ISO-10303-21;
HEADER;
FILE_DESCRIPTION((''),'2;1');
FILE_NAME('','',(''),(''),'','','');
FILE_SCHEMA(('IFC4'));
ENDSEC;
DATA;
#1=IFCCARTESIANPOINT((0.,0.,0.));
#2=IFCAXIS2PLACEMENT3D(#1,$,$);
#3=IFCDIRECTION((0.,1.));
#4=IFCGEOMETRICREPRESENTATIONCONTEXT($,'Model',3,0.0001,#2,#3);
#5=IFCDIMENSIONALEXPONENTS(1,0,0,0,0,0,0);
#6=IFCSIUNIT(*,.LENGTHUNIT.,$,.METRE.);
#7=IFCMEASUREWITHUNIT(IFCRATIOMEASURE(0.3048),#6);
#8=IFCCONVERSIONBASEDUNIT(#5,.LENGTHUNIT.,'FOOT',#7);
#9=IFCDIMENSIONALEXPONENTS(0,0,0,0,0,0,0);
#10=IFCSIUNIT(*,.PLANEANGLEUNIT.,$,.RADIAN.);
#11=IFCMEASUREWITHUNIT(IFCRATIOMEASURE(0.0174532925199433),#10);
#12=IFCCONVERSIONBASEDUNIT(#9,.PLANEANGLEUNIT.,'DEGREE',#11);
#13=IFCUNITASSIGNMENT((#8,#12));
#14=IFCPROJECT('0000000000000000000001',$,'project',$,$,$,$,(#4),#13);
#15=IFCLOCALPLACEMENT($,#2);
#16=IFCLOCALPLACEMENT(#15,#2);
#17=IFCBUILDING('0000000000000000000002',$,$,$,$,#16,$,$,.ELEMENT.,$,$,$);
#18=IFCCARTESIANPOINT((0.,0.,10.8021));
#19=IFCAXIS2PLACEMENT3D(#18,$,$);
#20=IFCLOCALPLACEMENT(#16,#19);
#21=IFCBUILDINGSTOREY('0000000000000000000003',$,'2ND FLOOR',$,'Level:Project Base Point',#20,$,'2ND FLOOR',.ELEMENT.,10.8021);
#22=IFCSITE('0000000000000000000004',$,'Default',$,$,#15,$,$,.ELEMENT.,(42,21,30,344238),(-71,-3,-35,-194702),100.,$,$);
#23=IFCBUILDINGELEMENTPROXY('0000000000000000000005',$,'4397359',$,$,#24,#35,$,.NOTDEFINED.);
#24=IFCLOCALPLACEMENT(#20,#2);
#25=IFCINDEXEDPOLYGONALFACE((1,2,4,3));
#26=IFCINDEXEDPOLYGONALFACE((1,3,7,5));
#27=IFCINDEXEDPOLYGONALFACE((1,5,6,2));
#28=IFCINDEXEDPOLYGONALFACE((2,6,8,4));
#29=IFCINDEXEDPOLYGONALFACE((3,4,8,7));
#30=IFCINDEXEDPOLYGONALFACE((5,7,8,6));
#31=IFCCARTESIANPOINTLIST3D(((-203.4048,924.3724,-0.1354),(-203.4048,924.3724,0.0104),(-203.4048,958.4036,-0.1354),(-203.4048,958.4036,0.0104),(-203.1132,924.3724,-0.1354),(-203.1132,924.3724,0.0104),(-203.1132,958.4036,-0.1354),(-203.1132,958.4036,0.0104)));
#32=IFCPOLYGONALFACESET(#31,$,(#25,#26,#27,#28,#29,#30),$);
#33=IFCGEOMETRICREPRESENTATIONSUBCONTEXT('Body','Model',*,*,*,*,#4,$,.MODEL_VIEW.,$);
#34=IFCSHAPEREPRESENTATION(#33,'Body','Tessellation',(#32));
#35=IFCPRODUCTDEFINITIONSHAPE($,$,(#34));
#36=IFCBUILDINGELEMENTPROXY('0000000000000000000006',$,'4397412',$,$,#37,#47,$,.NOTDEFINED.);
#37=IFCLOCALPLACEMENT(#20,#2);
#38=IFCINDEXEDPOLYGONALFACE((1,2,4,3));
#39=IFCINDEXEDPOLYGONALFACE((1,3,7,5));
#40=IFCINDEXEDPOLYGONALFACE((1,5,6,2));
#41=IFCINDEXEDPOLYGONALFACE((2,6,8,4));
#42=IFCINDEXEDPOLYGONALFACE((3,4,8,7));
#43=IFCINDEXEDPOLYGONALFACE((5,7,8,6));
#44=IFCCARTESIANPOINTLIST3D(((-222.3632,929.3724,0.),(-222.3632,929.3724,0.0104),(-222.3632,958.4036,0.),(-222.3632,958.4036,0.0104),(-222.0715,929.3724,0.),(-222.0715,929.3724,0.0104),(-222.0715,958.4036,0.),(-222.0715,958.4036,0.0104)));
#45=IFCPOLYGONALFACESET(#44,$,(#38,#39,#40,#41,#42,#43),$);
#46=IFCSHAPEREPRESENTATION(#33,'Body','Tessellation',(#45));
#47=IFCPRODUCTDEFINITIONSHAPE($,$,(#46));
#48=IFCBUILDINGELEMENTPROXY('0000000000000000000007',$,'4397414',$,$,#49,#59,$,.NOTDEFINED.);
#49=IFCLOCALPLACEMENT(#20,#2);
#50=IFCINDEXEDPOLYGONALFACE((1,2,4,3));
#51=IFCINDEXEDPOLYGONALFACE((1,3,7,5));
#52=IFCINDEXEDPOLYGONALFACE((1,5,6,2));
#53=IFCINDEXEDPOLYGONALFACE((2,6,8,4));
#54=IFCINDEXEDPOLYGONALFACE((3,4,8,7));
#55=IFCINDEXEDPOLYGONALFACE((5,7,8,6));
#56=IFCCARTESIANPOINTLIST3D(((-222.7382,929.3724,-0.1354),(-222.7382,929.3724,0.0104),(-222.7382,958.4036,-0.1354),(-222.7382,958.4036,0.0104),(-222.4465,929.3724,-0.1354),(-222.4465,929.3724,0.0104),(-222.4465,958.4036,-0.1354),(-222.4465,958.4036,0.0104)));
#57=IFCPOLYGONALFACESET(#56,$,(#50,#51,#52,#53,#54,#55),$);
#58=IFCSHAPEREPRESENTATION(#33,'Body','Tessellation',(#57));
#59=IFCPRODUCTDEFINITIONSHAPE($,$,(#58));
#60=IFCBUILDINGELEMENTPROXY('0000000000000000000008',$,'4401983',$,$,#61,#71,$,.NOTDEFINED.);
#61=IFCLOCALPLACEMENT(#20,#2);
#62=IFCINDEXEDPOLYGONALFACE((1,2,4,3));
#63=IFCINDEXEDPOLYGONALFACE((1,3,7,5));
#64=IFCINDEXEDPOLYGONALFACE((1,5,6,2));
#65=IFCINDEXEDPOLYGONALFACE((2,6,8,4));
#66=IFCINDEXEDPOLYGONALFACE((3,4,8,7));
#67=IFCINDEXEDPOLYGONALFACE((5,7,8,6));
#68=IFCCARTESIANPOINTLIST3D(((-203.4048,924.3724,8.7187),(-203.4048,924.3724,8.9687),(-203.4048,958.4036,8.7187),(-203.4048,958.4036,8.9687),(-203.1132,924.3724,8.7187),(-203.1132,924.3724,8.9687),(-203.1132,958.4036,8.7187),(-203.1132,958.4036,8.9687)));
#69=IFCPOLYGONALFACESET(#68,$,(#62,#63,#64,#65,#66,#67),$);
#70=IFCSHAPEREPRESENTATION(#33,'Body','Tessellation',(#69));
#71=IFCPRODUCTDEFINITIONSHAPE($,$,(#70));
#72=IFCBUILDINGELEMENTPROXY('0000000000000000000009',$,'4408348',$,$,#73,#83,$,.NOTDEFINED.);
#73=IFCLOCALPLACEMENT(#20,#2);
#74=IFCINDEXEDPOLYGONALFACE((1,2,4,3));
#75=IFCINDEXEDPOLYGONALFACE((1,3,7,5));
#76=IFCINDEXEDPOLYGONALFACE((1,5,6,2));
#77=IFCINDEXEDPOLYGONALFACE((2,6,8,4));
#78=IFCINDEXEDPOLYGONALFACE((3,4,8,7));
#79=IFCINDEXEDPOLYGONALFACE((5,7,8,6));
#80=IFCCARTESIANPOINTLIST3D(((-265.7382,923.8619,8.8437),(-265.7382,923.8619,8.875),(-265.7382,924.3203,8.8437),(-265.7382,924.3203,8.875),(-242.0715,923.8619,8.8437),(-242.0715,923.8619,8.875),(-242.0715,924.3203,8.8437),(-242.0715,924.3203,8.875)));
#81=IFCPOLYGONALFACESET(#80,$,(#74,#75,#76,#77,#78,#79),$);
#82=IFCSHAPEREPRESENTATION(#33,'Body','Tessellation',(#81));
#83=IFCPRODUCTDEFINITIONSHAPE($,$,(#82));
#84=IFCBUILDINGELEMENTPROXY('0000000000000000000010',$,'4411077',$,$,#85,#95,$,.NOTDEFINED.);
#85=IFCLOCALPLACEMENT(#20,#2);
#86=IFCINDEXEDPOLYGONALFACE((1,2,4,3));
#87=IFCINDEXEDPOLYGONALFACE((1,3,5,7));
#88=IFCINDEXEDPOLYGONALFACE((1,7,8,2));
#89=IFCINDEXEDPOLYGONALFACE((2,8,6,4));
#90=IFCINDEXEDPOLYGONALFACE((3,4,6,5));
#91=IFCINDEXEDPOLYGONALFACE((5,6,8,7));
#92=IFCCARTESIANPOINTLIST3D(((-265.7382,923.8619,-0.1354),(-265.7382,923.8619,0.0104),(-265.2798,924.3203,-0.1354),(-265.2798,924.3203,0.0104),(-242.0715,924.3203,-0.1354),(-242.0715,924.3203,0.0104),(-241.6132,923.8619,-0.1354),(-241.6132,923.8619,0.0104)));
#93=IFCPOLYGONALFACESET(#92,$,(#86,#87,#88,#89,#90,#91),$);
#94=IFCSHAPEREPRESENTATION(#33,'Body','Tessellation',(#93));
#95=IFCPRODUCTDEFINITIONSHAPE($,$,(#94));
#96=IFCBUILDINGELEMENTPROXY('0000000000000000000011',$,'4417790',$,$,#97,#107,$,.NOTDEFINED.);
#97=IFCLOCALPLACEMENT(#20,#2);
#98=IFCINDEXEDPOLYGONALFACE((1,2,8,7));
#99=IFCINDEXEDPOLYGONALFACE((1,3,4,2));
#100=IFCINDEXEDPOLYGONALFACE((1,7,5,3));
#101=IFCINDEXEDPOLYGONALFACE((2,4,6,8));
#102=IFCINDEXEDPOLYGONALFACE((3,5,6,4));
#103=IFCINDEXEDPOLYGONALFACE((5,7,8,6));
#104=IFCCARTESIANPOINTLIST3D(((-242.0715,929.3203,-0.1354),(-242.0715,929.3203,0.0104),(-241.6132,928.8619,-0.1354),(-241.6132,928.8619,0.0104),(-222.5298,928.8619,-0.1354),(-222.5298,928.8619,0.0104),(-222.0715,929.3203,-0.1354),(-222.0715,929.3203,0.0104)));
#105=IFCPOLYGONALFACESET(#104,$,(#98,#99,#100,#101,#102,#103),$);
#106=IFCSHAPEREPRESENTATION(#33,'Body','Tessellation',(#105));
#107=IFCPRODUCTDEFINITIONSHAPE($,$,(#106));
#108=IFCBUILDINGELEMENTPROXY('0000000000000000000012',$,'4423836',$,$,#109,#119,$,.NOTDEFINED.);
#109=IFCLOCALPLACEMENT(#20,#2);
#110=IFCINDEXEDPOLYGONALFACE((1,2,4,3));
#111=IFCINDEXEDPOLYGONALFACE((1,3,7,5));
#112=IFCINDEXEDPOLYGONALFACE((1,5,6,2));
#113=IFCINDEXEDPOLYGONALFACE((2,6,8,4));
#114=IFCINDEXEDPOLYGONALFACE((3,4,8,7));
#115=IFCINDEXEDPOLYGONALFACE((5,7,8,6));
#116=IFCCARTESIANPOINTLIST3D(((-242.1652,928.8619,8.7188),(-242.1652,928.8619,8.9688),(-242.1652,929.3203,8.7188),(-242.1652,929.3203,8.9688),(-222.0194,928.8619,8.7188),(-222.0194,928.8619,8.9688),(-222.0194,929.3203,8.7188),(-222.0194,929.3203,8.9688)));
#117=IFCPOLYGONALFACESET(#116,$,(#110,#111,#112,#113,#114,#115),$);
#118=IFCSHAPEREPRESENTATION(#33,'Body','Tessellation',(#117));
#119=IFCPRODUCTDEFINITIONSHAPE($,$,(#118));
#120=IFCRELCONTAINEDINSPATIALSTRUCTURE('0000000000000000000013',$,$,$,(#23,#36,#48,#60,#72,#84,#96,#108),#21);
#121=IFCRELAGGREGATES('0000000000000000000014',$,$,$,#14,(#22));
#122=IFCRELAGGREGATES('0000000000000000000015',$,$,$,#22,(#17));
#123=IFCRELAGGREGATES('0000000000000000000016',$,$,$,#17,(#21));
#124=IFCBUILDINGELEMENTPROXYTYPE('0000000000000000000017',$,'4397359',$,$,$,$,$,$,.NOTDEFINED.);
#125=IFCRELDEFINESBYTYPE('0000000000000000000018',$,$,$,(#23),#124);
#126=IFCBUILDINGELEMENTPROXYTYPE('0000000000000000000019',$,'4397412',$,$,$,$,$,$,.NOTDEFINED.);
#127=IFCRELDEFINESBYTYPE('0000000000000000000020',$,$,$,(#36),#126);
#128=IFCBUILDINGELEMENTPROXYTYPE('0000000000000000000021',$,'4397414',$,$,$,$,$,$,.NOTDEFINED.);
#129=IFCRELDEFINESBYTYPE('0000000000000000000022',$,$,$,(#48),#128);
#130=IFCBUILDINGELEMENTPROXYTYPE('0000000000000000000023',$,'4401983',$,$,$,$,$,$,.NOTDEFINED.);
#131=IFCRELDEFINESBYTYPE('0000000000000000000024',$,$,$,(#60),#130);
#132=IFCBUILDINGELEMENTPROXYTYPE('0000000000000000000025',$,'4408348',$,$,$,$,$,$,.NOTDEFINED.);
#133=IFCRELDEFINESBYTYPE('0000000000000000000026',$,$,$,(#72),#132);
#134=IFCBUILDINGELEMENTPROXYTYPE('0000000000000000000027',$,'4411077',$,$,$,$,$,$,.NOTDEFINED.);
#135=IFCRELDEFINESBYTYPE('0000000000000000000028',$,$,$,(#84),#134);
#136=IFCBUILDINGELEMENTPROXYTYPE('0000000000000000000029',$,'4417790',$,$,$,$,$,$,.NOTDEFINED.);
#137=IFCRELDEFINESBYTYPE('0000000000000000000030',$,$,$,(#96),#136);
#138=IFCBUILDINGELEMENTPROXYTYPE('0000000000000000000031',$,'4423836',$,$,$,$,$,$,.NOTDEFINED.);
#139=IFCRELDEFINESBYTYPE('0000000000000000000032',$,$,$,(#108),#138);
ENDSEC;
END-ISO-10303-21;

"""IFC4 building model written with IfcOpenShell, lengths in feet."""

from ifc_helpers import new_model, entity, si_unit, converted_unit, direction, frame, frame_2d, origin, origin_2d_with_axis, place, context, subcontext, project, spatial, polyline, rectangle, outline, extrude, type_object, element, save


model = new_model("IFC4")

# Units and contexts
model_context = context("Model", 3, precision=0.0001, world=origin(), true_north=direction((0.0, 1.0)))
body_context = subcontext(model_context, "Body", "Model", "MODEL_VIEW")
ifc_project = project(units=[converted_unit("LENGTHUNIT", "FOOT", entity("IfcRatioMeasure", 0.3048), si_unit("LENGTHUNIT", "METRE"), dimensions=[1, 0, 0, 0, 0, 0, 0]), converted_unit("PLANEANGLEUNIT", "DEGREE", entity("IfcRatioMeasure", 0.0174532925199433), si_unit("PLANEANGLEUNIT", "RADIAN"), dimensions=[0, 0, 0, 0, 0, 0, 0])], contexts=[model_context])

# Site, building, storey
site_placement = place(None, origin())
site = spatial("IfcSite", under=ifc_project, at=site_placement, Name="Default", CompositionType="ELEMENT", RefLatitude=(42, 21, 30, 344238), RefLongitude=(-71, -3, -35, -194702), RefElevation=100.0)
building_placement = place(site_placement, origin())
building = spatial("IfcBuilding", under=site, at=building_placement, CompositionType="ELEMENT")
storey_placement = place(building_placement, frame((0.0, 0.0, 10.8021)))
storey = spatial("IfcBuildingStorey", under=building, at=storey_placement, Name="2ND FLOOR", ObjectType="Level:Project Base Point", LongName="2ND FLOOR", CompositionType="ELEMENT", Elevation=10.8021)

# Building element proxies
building_element_proxy_type_1 = type_object("IfcBuildingElementProxyType", Name="4397359", PredefinedType="NOTDEFINED")
proxy_1_placement = place(storey_placement, frame((-203.4048, 924.3724, -0.1354)))
element("IfcBuildingElementProxy", 1, at=proxy_1_placement, inside=storey, type_object=building_element_proxy_type_1, Name="4397359", PredefinedType="NOTDEFINED", context=body_context, shape_type="SweptSolid", body=[
    extrude(rectangle(XDim=34.0313, YDim=0.2917, at=frame_2d((0.0, 0.0), x_axis=(1.0, 0.0))), frame((0.1458, 17.0156, 0.0), z_axis=(0.0, 0.0, 1.0), x_axis=(0.0, 1.0, 0.0)), (0.0, 0.0, 1.0), 0.1458),
])
building_element_proxy_type_2 = type_object("IfcBuildingElementProxyType", Name="4397412", PredefinedType="NOTDEFINED")
proxy_2_placement = place(storey_placement, frame((-222.3632, 929.3724, 0.0)))
element("IfcBuildingElementProxy", 2, at=proxy_2_placement, inside=storey, type_object=building_element_proxy_type_2, Name="4397412", PredefinedType="NOTDEFINED", context=body_context, shape_type="SweptSolid", body=[
    extrude(rectangle(XDim=29.0313, YDim=0.2917, at=origin_2d_with_axis()), frame((0.1458, 14.5156, 0.0), z_axis=(0.0, 0.0, 1.0), x_axis=(0.0, 1.0, 0.0)), (0.0, 0.0, 1.0), 0.0104),
])
building_element_proxy_type_3 = type_object("IfcBuildingElementProxyType", Name="4397414", PredefinedType="NOTDEFINED")
proxy_3_placement = place(storey_placement, frame((-222.7382, 929.3724, -0.1354)))
element("IfcBuildingElementProxy", 3, at=proxy_3_placement, inside=storey, type_object=building_element_proxy_type_3, Name="4397414", PredefinedType="NOTDEFINED", context=body_context, shape_type="SweptSolid", body=[
    extrude(rectangle(XDim=29.0313, YDim=0.2917, at=origin_2d_with_axis()), frame((0.1458, 14.5156, 0.0), z_axis=(0.0, 0.0, 1.0), x_axis=(0.0, 1.0, 0.0)), (0.0, 0.0, 1.0), 0.1458),
])
building_element_proxy_type_4 = type_object("IfcBuildingElementProxyType", Name="4401983", PredefinedType="NOTDEFINED")
proxy_4_placement = place(storey_placement, frame((-203.4048, 924.3724, 8.7187)))
element("IfcBuildingElementProxy", 4, at=proxy_4_placement, inside=storey, type_object=building_element_proxy_type_4, Name="4401983", PredefinedType="NOTDEFINED", context=body_context, shape_type="SweptSolid", body=[
    extrude(rectangle(XDim=34.0313, YDim=0.2917, at=frame_2d((0.0, 0.0), x_axis=(1.0, 0.0))), frame((0.1458, 17.0156, 0.0), z_axis=(0.0, 0.0, 1.0), x_axis=(0.0, 1.0, 0.0)), (0.0, 0.0, 1.0), 0.25),
])
building_element_proxy_type_5 = type_object("IfcBuildingElementProxyType", Name="4408348", PredefinedType="NOTDEFINED")
proxy_5_placement = place(storey_placement, frame((-265.7382, 923.8619, 8.8437)))
element("IfcBuildingElementProxy", 5, at=proxy_5_placement, inside=storey, type_object=building_element_proxy_type_5, Name="4408348", PredefinedType="NOTDEFINED", context=body_context, shape_type="SweptSolid", body=[
    extrude(rectangle(XDim=23.6667, YDim=0.4583, at=frame_2d((-0.0911, 0.0), x_axis=(1.0, 0.0))), frame((11.9245, 0.2292, 0.0)), (0.0, 0.0, 1.0), 0.0313),
])
building_element_proxy_type_6 = type_object("IfcBuildingElementProxyType", Name="4411077", PredefinedType="NOTDEFINED")
proxy_6_placement = place(storey_placement, frame((-265.7382, 923.8619, -0.1354)))
element("IfcBuildingElementProxy", 6, at=proxy_6_placement, inside=storey, type_object=building_element_proxy_type_6, Name="4411077", PredefinedType="NOTDEFINED", context=body_context, shape_type="SweptSolid", body=[
    extrude(outline(polyline([(-12.0625, -0.2292), (12.0625, -0.2292), (11.6042, 0.2292), (-11.6042, 0.2292), (-12.0625, -0.2292)])), frame((12.0625, 0.2292, 0.0)), (0.0, 0.0, 1.0), 0.1458),
])
building_element_proxy_type_7 = type_object("IfcBuildingElementProxyType", Name="4417790", PredefinedType="NOTDEFINED")
proxy_7_placement = place(storey_placement, frame((-242.0715, 928.8619, -0.1354)))
element("IfcBuildingElementProxy", 7, at=proxy_7_placement, inside=storey, type_object=building_element_proxy_type_7, Name="4417790", PredefinedType="NOTDEFINED", context=body_context, shape_type="SweptSolid", body=[
    extrude(outline(polyline([(-9.5417, -0.2292), (9.5417, -0.2292), (10.0, 0.2292), (-10.0, 0.2292), (-9.5417, -0.2292)])), frame((10.0, 0.2292, 0.0)), (0.0, 0.0, 1.0), 0.1458),
])
building_element_proxy_type_8 = type_object("IfcBuildingElementProxyType", Name="4423836", PredefinedType="NOTDEFINED")
proxy_8_placement = place(storey_placement, frame((-242.1652, 928.8619, 8.7188)))
element("IfcBuildingElementProxy", 8, at=proxy_8_placement, inside=storey, type_object=building_element_proxy_type_8, Name="4423836", PredefinedType="NOTDEFINED", context=body_context, shape_type="SweptSolid", body=[
    extrude(rectangle(XDim=20.1458, YDim=0.4583, at=frame_2d((0.0, 0.0), x_axis=(1.0, 0.0))), frame((10.0729, 0.2292, 0.0)), (0.0, 0.0, 1.0), 0.25),
])

save(model, "model.ifc")
